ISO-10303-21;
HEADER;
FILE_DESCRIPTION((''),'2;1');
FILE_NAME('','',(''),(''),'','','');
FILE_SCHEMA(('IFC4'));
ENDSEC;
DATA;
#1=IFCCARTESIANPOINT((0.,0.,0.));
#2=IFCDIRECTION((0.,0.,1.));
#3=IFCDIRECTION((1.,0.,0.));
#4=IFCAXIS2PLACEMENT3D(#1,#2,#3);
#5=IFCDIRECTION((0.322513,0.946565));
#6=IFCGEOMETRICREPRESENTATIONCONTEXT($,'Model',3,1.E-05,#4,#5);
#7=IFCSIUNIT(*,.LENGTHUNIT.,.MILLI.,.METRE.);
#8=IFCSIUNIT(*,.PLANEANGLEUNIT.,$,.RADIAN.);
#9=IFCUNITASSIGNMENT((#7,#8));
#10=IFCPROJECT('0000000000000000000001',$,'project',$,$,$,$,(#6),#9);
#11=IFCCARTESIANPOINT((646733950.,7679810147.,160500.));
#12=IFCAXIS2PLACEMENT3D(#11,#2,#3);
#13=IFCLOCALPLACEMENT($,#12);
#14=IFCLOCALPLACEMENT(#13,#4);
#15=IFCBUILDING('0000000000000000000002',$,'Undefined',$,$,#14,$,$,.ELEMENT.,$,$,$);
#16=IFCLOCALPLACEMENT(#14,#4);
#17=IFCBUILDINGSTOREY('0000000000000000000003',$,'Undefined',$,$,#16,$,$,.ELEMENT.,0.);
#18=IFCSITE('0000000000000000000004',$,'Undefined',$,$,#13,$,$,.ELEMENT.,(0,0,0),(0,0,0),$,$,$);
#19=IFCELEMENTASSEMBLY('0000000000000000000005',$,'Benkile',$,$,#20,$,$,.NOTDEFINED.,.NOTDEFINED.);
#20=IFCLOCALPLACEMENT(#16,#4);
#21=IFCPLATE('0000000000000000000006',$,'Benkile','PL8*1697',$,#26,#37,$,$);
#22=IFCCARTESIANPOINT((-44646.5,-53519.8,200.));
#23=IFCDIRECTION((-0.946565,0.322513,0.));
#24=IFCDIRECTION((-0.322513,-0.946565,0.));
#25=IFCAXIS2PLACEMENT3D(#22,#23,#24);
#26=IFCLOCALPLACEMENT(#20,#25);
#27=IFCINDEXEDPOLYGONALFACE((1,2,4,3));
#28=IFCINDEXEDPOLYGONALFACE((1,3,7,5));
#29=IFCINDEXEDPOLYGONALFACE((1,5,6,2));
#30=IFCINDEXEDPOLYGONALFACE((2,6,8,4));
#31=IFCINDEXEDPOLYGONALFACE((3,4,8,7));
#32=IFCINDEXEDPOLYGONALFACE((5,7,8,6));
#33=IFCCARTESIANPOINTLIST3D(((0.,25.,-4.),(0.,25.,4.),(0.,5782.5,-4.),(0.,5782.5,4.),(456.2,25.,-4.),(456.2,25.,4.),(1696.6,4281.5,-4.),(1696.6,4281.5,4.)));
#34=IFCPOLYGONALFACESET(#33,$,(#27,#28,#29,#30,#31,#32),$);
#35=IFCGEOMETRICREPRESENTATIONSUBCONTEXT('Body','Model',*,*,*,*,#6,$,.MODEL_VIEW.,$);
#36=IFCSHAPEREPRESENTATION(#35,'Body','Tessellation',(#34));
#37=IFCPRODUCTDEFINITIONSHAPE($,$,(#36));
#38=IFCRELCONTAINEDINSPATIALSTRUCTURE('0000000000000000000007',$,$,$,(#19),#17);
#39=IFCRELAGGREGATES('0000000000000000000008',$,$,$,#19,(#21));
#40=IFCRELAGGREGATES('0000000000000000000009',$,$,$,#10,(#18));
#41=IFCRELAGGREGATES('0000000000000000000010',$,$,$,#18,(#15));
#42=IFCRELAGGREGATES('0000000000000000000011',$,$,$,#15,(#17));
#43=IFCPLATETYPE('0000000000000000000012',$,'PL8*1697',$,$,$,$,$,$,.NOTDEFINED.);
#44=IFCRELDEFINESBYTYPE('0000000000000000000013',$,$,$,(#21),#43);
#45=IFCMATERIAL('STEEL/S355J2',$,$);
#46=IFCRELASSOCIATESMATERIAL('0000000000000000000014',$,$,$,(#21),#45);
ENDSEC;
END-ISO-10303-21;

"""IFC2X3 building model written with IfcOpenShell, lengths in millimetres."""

from ifc_helpers import new_model, si_unit, direction, frame, origin_with_axes, place, context, subcontext, project, spatial, polyline, outline, extrude, clip, halfspace, material, type_object, element, aggregate, save


model = new_model("IFC2X3")

# Units and contexts
model_context = context("Model", 3, precision=1e-05, world=origin_with_axes(), true_north=direction((0.322513, 0.946565)))
body_context = subcontext(model_context, "Body", "Model", "MODEL_VIEW")
ifc_project = project(units=[si_unit("LENGTHUNIT", "METRE", prefix="MILLI"), si_unit("PLANEANGLEUNIT", "RADIAN")], contexts=[model_context])

# Site, building, storey
site_placement = place(None, frame((646733950.0, 7679810147.0, 160500.0), z_axis=(0.0, 0.0, 1.0), x_axis=(1.0, 0.0, 0.0)))
site = spatial("IfcSite", under=ifc_project, at=site_placement, Name="Undefined", CompositionType="ELEMENT", RefLatitude=(0, 0, 0), RefLongitude=(0, 0, 0))
building_placement = place(site_placement, origin_with_axes())
building = spatial("IfcBuilding", under=site, at=building_placement, Name="Undefined", CompositionType="ELEMENT")
storey_placement = place(building_placement, origin_with_axes())
storey = spatial("IfcBuildingStorey", under=building, at=storey_placement, Name="Undefined", CompositionType="ELEMENT", Elevation=0.0)

# Shared definitions
ifc_material_1 = material(Name="STEEL/S355J2")

# Element assembly
assembly_1_placement = place(storey_placement, origin_with_axes())
assembly_1 = element("IfcElementAssembly", 1, at=assembly_1_placement, inside=storey, Name="Benkile", AssemblyPlace="NOTDEFINED", PredefinedType="NOTDEFINED")

# Plate
plate_type_1 = type_object("IfcPlateType", Name="PL8*1697", PredefinedType="NOTDEFINED")
plate_1_placement = place(assembly_1_placement, frame((-44646.5, -53519.8, 200.0), z_axis=(-0.946565, 0.322513, 0.0), x_axis=(-0.322513, -0.946565, 0.0)))
plate_1 = element("IfcPlate", 2, at=plate_1_placement, type_object=plate_type_1, material=ifc_material_1, Name="Benkile", Description="PL8*1697", context=body_context, shape_type="Clipping", body=[
    clip(extrude(outline(polyline([(0.0, 0.0), (449.0, 0.0), (1696.6, 4281.5), (0.0, 5782.5), (0.0, 0.0)])), frame((0.0, 0.0, -4.0), z_axis=(0.0, 0.0, 1.0), x_axis=(1.0, 0.0, 0.0)), (0.0, 0.0, 1.0), 8.0), halfspace(frame((0.0, 25.0, -4.0), z_axis=(0.0, -1.0, 0.0), x_axis=(0.0, 0.0, 1.0)), False)),
])

aggregate(assembly_1, [plate_1])

save(model, "model.ifc")
